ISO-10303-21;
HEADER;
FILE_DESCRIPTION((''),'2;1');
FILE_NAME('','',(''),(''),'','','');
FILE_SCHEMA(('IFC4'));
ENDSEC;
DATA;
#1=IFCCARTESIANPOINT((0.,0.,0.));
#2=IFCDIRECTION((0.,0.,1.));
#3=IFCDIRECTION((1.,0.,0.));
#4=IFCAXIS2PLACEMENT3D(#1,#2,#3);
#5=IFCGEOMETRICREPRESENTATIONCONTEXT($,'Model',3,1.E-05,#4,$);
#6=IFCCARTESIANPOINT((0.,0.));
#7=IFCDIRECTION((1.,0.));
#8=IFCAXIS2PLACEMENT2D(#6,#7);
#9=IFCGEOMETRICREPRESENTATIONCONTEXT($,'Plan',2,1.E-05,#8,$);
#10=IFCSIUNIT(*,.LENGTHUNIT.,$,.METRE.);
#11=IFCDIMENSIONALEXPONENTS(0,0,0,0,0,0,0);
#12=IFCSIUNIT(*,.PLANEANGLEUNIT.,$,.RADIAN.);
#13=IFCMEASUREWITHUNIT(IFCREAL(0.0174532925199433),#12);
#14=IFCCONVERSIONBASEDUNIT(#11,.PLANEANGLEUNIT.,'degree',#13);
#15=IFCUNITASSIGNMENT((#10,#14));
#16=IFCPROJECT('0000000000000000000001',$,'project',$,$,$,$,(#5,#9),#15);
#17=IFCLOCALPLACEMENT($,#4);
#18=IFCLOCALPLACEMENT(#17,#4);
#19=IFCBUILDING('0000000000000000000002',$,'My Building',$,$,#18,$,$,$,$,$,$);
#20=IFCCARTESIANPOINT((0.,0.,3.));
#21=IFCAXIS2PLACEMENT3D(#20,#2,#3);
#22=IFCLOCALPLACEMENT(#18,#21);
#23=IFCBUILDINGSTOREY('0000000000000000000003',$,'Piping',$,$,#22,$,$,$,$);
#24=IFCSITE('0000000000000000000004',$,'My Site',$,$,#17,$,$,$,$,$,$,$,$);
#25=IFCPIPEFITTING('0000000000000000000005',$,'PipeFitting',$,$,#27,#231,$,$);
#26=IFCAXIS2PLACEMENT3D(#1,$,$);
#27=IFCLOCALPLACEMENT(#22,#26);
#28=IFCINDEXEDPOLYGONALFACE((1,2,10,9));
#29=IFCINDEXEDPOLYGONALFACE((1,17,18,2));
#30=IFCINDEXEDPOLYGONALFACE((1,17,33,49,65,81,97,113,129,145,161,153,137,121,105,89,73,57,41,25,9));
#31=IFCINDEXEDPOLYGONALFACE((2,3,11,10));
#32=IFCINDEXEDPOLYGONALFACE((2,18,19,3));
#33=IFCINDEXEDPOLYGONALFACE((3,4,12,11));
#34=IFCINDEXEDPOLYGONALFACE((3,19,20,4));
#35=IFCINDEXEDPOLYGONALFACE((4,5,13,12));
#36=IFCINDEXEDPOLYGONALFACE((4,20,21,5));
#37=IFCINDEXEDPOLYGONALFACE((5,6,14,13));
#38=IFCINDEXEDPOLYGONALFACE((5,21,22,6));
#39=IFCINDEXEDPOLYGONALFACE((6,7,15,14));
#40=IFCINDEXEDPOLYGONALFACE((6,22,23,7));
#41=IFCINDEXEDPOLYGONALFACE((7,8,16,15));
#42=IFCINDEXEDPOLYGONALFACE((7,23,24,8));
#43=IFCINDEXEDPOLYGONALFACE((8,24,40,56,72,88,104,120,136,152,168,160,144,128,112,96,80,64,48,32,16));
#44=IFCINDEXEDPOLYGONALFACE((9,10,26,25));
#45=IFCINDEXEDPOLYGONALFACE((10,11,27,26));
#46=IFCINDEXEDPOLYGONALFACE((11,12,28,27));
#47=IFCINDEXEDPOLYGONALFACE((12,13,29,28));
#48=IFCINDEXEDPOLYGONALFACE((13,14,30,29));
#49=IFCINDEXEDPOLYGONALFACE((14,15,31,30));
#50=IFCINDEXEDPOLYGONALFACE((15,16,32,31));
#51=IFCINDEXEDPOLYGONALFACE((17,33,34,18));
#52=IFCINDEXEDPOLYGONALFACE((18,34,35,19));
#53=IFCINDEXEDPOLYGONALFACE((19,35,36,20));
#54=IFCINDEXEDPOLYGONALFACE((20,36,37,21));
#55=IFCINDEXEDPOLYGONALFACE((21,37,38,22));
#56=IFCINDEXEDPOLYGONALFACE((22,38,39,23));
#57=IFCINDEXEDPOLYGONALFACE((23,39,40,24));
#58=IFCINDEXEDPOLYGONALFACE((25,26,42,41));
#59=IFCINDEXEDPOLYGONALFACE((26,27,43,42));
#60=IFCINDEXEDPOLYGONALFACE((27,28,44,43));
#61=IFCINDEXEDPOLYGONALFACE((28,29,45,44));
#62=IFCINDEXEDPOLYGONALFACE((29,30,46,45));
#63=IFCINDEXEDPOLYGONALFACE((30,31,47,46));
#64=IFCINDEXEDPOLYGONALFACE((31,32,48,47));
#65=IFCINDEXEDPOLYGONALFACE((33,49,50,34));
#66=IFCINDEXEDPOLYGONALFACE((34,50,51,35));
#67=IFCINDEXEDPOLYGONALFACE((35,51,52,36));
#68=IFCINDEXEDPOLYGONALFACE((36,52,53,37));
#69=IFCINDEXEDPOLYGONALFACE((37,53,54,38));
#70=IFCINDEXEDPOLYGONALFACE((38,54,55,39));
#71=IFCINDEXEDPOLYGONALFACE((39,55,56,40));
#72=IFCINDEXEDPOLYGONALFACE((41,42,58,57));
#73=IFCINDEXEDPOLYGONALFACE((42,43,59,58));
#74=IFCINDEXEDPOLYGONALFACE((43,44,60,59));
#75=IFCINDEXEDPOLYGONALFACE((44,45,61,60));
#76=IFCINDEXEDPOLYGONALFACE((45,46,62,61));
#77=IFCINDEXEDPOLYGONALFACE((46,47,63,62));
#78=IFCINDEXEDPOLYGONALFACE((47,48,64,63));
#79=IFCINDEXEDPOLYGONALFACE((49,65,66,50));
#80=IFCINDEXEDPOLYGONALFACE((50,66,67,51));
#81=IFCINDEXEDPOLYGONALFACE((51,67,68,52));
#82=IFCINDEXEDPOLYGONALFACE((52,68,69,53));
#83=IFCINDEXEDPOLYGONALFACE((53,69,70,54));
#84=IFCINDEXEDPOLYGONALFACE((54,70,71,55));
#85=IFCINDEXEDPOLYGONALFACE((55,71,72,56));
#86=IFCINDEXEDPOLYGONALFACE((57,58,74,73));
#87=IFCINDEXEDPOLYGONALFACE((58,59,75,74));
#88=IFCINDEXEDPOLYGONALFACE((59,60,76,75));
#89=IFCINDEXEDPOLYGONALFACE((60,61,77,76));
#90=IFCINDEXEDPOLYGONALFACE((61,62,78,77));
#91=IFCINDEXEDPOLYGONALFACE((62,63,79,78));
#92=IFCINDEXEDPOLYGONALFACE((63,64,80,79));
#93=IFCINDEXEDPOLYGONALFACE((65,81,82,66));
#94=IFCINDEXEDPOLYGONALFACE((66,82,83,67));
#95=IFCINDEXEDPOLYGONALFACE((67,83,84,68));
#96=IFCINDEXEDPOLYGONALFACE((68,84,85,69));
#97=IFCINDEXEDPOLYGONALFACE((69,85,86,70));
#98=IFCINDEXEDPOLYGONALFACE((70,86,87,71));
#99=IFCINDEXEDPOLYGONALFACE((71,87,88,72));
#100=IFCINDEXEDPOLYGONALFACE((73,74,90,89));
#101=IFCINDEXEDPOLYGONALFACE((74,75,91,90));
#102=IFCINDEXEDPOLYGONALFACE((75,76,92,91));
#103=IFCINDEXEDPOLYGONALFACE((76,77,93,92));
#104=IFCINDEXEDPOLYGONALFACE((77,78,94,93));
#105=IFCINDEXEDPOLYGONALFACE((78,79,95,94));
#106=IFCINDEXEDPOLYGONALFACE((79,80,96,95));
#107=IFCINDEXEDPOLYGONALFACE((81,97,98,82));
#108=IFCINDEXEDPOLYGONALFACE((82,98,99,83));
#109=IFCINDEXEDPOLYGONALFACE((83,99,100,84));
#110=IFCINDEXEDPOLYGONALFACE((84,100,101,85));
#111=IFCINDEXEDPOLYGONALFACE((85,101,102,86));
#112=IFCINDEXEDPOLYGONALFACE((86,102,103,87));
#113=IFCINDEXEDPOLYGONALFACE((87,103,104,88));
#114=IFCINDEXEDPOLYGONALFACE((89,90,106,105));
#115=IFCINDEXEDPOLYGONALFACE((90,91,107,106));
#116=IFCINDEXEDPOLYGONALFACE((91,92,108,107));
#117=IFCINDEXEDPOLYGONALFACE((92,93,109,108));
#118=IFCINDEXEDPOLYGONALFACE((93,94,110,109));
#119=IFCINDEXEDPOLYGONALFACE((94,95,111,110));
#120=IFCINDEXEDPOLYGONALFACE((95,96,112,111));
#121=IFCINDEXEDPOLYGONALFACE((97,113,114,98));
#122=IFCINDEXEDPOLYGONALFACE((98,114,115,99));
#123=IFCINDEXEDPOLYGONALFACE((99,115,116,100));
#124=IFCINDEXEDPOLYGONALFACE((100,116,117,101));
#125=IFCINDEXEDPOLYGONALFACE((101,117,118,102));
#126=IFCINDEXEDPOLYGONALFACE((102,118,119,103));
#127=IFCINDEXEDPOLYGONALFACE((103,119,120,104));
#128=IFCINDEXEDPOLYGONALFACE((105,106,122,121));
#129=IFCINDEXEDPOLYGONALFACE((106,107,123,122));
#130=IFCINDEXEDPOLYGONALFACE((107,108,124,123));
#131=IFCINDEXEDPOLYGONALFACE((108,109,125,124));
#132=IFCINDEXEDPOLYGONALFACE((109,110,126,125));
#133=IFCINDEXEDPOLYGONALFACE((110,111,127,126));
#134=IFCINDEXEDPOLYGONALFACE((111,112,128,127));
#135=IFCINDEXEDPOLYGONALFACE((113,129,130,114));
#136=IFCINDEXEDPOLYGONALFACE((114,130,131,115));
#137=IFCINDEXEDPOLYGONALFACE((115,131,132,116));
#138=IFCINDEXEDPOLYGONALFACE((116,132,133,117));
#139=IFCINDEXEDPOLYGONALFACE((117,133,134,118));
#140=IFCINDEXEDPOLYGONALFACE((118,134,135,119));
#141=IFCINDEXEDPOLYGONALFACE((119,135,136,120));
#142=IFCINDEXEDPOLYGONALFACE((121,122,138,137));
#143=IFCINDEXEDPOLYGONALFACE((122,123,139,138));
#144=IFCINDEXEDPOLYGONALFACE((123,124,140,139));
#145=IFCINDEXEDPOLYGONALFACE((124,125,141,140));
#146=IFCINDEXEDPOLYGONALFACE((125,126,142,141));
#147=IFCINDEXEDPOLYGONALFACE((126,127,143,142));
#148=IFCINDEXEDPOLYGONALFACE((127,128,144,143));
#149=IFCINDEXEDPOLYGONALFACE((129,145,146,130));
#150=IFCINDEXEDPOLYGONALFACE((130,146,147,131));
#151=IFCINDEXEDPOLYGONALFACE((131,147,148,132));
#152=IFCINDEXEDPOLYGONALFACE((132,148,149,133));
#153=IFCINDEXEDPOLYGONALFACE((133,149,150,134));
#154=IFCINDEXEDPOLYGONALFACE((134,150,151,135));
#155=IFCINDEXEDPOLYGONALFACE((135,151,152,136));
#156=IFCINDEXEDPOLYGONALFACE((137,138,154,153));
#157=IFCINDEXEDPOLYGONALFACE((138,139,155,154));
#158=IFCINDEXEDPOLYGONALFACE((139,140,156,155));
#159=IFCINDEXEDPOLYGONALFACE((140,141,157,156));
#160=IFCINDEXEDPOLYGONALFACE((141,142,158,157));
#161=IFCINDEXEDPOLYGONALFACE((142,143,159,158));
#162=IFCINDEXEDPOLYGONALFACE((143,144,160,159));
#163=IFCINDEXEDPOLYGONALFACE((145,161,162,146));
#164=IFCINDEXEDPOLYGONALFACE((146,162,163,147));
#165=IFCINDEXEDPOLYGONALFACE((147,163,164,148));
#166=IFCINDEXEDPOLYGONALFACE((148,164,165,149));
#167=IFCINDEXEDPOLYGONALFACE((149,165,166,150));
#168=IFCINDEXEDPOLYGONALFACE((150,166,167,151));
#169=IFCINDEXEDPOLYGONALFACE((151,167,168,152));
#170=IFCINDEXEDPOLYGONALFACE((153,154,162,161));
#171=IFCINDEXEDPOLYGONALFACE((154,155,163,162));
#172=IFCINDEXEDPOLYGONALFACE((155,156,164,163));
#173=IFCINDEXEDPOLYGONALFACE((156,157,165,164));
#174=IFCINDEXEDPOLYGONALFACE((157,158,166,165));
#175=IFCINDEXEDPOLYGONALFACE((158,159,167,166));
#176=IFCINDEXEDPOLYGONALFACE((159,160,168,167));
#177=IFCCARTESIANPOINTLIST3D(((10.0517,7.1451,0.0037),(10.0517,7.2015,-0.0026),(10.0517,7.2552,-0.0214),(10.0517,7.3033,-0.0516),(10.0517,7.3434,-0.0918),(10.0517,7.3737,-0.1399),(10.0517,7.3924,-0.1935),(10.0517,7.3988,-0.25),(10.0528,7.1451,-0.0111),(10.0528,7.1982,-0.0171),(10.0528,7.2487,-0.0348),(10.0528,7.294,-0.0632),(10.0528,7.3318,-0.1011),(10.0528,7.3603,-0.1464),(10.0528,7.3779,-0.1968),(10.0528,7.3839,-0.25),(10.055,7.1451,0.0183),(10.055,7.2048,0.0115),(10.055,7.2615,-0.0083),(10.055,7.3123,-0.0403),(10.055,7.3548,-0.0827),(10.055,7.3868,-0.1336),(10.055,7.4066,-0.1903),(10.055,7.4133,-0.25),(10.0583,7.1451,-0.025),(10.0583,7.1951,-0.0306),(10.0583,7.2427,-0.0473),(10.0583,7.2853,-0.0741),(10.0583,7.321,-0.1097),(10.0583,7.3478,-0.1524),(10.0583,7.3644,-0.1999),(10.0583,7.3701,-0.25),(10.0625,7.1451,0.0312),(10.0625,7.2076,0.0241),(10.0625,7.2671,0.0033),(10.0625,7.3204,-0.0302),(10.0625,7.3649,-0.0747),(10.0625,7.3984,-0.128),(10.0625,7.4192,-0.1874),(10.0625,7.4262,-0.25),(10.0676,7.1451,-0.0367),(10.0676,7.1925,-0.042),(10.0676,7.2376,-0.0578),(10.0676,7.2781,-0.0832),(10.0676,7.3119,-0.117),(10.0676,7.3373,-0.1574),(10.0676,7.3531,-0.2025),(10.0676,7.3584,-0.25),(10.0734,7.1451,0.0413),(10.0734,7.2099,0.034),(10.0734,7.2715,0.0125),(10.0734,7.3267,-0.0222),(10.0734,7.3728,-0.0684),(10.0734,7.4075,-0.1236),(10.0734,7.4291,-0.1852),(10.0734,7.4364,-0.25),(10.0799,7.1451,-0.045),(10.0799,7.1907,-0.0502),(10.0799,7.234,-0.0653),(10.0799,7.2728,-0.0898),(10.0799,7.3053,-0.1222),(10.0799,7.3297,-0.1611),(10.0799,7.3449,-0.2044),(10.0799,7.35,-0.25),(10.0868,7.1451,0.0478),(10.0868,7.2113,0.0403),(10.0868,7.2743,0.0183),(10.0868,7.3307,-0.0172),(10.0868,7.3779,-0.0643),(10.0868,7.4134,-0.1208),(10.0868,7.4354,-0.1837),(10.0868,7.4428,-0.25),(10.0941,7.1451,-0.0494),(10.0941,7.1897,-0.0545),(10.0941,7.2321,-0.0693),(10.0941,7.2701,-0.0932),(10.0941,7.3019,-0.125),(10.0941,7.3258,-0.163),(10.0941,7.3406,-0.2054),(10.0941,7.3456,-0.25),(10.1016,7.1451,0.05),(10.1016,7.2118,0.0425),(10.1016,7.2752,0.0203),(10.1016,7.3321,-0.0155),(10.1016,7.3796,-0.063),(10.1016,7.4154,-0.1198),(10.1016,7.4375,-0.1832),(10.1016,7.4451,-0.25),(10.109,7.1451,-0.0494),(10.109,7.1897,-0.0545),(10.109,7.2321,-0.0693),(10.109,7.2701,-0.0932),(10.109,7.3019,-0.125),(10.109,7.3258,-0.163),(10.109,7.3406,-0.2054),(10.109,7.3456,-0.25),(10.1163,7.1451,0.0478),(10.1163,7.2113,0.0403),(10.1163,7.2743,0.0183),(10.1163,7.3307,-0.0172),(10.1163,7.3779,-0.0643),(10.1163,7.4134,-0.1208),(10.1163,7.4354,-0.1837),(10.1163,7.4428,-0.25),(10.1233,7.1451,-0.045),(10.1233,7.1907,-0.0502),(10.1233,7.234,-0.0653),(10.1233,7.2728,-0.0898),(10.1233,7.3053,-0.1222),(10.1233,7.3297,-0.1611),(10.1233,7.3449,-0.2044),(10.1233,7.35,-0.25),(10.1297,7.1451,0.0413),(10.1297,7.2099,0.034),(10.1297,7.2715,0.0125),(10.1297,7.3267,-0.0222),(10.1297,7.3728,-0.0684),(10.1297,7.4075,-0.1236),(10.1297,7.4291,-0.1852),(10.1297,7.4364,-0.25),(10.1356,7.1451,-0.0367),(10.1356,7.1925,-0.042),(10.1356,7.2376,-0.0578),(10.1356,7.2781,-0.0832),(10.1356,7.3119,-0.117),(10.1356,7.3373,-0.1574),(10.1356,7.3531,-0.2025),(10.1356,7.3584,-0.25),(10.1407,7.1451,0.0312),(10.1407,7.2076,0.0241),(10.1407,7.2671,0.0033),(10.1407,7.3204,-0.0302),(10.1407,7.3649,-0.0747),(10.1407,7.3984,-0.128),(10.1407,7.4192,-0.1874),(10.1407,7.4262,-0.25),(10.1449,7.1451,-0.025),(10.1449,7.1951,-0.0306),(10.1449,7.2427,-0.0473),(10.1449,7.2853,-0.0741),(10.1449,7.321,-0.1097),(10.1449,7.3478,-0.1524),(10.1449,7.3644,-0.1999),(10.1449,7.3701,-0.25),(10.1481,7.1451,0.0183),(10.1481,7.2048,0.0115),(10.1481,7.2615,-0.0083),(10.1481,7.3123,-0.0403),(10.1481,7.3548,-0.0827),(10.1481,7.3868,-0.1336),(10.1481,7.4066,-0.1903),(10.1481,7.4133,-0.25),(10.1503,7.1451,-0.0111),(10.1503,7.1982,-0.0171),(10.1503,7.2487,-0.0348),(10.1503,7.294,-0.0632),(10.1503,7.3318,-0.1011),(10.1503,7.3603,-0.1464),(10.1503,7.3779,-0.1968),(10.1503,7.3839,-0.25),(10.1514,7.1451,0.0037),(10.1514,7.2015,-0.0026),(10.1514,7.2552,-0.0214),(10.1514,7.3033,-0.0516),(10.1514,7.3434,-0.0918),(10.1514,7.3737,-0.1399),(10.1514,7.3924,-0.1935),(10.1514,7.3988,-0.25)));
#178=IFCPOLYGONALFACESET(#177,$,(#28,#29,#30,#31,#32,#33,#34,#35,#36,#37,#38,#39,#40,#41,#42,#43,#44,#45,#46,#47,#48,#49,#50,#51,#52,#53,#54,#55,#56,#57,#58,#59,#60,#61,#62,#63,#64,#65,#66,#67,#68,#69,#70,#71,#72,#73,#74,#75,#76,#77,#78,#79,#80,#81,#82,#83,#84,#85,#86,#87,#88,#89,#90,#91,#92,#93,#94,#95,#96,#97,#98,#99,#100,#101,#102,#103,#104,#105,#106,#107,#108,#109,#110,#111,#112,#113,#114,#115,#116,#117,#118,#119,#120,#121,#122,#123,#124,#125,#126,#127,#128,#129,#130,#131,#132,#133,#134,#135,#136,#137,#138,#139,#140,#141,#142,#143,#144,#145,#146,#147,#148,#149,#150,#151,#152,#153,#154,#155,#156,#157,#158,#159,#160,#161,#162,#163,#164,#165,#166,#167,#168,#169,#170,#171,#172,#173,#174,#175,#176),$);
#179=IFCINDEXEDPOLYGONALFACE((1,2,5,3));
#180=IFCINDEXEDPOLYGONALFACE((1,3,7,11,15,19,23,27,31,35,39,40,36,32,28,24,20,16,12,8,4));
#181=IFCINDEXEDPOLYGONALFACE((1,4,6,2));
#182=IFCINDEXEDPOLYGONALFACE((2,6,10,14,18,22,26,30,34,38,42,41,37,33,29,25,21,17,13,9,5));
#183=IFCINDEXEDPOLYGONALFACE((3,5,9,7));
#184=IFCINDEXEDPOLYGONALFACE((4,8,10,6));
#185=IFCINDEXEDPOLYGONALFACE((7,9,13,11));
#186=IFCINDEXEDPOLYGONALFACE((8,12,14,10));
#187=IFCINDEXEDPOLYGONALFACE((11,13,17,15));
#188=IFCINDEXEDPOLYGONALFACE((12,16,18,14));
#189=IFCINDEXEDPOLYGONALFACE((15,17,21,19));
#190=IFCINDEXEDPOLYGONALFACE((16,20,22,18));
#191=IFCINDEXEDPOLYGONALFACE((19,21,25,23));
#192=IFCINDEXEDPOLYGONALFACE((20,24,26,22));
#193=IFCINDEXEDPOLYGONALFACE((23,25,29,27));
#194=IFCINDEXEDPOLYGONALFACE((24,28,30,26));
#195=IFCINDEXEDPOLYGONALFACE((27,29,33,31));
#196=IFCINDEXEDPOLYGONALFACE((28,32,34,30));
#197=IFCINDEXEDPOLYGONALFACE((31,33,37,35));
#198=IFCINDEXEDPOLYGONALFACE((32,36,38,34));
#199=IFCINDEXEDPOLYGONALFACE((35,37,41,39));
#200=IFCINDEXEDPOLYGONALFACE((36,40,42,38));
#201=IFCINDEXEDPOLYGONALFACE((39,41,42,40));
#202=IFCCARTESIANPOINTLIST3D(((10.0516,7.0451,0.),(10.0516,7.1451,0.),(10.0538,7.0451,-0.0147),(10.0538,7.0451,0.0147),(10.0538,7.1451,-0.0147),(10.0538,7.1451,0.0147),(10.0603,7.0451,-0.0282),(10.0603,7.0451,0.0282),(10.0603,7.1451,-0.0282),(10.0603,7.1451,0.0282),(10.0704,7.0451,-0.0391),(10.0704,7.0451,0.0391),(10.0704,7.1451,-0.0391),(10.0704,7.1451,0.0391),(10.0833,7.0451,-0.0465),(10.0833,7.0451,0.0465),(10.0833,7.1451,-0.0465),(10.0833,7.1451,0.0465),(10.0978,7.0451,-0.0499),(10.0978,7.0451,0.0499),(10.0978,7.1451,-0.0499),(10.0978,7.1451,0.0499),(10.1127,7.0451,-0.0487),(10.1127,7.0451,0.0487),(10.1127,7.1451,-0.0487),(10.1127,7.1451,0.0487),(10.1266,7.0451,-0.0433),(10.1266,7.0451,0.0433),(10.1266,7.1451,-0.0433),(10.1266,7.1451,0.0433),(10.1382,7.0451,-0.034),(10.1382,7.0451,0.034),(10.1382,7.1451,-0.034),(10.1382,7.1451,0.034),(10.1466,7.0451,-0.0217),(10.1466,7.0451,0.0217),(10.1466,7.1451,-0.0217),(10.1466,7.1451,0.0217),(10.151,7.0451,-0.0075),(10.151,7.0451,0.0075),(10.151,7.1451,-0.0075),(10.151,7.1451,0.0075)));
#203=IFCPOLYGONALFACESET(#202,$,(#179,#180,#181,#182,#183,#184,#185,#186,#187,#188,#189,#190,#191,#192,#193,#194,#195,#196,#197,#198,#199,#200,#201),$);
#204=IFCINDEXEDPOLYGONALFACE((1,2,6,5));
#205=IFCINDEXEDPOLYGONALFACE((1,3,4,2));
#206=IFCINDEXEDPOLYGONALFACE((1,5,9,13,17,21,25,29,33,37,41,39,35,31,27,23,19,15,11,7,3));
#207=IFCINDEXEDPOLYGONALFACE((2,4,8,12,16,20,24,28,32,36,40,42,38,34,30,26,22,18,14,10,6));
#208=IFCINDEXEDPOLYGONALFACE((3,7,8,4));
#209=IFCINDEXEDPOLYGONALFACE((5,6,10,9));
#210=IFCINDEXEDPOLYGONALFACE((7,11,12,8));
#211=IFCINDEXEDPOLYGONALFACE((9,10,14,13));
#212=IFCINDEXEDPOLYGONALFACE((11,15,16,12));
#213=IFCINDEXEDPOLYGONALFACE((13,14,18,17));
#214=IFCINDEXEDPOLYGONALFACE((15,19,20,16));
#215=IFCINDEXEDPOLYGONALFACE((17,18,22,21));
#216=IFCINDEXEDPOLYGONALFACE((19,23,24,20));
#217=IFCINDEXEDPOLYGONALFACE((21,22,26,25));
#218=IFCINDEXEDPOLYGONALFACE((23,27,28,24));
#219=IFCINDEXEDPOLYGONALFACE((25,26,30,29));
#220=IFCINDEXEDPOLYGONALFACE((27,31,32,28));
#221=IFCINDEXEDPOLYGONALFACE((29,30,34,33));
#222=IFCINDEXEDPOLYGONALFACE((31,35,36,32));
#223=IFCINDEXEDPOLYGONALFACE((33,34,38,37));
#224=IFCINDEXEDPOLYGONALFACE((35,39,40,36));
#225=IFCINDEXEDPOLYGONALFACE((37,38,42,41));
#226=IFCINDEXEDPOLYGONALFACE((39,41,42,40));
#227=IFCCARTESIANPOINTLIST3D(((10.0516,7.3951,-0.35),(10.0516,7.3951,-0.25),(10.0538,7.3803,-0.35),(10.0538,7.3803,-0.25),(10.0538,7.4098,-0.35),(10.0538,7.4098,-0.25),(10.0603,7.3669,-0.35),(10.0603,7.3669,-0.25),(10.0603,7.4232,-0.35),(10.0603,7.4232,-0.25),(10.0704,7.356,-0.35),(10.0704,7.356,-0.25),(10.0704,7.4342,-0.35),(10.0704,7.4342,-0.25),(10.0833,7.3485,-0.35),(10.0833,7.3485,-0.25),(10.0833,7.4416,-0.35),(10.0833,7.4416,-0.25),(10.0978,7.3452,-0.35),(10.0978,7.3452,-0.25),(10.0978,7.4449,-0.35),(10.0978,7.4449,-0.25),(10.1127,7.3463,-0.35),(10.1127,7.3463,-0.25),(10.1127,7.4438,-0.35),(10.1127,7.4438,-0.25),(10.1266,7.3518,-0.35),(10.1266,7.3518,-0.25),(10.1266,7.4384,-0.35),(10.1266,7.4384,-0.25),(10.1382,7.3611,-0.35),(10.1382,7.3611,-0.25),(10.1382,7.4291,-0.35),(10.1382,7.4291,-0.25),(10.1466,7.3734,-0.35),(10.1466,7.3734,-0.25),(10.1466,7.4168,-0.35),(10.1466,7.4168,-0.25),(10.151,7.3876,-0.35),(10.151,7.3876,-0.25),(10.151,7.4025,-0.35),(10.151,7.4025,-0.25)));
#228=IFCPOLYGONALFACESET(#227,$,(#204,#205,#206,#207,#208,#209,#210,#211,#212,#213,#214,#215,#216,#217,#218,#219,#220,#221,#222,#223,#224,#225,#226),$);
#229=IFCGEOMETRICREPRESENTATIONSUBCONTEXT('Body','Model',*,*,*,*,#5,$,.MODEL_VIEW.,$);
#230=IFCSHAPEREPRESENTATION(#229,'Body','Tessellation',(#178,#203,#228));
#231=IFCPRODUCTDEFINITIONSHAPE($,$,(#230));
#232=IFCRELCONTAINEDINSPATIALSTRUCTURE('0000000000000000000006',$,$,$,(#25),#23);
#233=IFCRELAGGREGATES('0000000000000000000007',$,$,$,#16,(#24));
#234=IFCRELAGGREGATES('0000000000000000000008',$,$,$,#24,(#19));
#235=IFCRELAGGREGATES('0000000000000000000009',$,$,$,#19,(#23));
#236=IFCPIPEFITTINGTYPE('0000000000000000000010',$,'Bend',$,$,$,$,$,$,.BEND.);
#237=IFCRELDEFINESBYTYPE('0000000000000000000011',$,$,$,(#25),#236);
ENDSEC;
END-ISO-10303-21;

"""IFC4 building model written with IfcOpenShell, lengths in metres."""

from ifc_helpers import new_model, entity, si_unit, converted_unit, frame, origin_with_axes, origin_2d_with_axis, place, context, subcontext, project, spatial, circle, extrude, source, transform, mapped, type_object, type_shapes, element, save


model = new_model("IFC4")

# Units and contexts
model_context = context("Model", 3, precision=1e-05, world=origin_with_axes())
plan_context = context("Plan", 2, precision=1e-05, world=origin_2d_with_axis())
body_context = subcontext(model_context, "Body", "Model", "MODEL_VIEW")
ifc_project = project(units=[si_unit("LENGTHUNIT", "METRE"), converted_unit("PLANEANGLEUNIT", "degree", entity("IfcReal", 0.0174532925199433), si_unit("PLANEANGLEUNIT", "RADIAN"), dimensions=[0, 0, 0, 0, 0, 0, 0])], contexts=[model_context, plan_context])

# Site, building, storey
site_placement = place(None, origin_with_axes())
site = spatial("IfcSite", under=ifc_project, at=site_placement, Name="My Site")
building_placement = place(site_placement, origin_with_axes())
building = spatial("IfcBuilding", under=site, at=building_placement, Name="My Building")
storey_placement = place(building_placement, frame((0.0, 0.0, 3.0), z_axis=(0.0, 0.0, 1.0), x_axis=(1.0, 0.0, 0.0)))
storey = spatial("IfcBuildingStorey", under=building, at=storey_placement, Name="Piping")

# Pipe fitting
pipe_fitting_type = type_object("IfcPipeFittingType", Name="Bend", PredefinedType="BEND")
shared_shape = source(origin_with_axes(), body_context, "Body", "SolidModel", [
    entity("IfcSweptDiskSolid", entity("IfcIndexedPolyCurve", entity("IfcCartesianPointList3D", [[0.0, 0.0, -0.1], [0.0, 0.0732, -0.2768], [0.0, 0.25, -0.35]]), [entity("IfcArcIndex", [1, 2, 3])]), 0.05),
    extrude(circle(Radius=0.05), origin_with_axes(), (0.0, 0.0, -1.0), 0.1),
    extrude(circle(Radius=0.05), frame((0.0, 0.25, -0.35), z_axis=(0.0, 1.0, 0.0), x_axis=(1.0, 0.0, 0.0)), (0.0, 0.0, 1.0), 0.1),
])
type_shapes(pipe_fitting_type, [shared_shape])
for number, where, z_axis, x_axis, name in (
    (1, (10.1016, 7.0451, 0.0), (0.0, -1.0, 0.0), (-1.0, 0.0, 0.0), "PipeFitting"),
):
    element("IfcPipeFitting", number, at=place(storey_placement, frame(where, z_axis=z_axis, x_axis=x_axis)), inside=storey, type_object=pipe_fitting_type, Name=name, context=body_context, shape_type="MappedRepresentation", body=[
        mapped(shared_shape, transform((0.0, 0.0, 0.0), x_axis=(1.0, 0.0, 0.0), y_axis=(0.0, 1.0, 0.0), z_axis=(0.0, 0.0, 1.0), scale=1.0)),
    ])

save(model, "model.ifc")
